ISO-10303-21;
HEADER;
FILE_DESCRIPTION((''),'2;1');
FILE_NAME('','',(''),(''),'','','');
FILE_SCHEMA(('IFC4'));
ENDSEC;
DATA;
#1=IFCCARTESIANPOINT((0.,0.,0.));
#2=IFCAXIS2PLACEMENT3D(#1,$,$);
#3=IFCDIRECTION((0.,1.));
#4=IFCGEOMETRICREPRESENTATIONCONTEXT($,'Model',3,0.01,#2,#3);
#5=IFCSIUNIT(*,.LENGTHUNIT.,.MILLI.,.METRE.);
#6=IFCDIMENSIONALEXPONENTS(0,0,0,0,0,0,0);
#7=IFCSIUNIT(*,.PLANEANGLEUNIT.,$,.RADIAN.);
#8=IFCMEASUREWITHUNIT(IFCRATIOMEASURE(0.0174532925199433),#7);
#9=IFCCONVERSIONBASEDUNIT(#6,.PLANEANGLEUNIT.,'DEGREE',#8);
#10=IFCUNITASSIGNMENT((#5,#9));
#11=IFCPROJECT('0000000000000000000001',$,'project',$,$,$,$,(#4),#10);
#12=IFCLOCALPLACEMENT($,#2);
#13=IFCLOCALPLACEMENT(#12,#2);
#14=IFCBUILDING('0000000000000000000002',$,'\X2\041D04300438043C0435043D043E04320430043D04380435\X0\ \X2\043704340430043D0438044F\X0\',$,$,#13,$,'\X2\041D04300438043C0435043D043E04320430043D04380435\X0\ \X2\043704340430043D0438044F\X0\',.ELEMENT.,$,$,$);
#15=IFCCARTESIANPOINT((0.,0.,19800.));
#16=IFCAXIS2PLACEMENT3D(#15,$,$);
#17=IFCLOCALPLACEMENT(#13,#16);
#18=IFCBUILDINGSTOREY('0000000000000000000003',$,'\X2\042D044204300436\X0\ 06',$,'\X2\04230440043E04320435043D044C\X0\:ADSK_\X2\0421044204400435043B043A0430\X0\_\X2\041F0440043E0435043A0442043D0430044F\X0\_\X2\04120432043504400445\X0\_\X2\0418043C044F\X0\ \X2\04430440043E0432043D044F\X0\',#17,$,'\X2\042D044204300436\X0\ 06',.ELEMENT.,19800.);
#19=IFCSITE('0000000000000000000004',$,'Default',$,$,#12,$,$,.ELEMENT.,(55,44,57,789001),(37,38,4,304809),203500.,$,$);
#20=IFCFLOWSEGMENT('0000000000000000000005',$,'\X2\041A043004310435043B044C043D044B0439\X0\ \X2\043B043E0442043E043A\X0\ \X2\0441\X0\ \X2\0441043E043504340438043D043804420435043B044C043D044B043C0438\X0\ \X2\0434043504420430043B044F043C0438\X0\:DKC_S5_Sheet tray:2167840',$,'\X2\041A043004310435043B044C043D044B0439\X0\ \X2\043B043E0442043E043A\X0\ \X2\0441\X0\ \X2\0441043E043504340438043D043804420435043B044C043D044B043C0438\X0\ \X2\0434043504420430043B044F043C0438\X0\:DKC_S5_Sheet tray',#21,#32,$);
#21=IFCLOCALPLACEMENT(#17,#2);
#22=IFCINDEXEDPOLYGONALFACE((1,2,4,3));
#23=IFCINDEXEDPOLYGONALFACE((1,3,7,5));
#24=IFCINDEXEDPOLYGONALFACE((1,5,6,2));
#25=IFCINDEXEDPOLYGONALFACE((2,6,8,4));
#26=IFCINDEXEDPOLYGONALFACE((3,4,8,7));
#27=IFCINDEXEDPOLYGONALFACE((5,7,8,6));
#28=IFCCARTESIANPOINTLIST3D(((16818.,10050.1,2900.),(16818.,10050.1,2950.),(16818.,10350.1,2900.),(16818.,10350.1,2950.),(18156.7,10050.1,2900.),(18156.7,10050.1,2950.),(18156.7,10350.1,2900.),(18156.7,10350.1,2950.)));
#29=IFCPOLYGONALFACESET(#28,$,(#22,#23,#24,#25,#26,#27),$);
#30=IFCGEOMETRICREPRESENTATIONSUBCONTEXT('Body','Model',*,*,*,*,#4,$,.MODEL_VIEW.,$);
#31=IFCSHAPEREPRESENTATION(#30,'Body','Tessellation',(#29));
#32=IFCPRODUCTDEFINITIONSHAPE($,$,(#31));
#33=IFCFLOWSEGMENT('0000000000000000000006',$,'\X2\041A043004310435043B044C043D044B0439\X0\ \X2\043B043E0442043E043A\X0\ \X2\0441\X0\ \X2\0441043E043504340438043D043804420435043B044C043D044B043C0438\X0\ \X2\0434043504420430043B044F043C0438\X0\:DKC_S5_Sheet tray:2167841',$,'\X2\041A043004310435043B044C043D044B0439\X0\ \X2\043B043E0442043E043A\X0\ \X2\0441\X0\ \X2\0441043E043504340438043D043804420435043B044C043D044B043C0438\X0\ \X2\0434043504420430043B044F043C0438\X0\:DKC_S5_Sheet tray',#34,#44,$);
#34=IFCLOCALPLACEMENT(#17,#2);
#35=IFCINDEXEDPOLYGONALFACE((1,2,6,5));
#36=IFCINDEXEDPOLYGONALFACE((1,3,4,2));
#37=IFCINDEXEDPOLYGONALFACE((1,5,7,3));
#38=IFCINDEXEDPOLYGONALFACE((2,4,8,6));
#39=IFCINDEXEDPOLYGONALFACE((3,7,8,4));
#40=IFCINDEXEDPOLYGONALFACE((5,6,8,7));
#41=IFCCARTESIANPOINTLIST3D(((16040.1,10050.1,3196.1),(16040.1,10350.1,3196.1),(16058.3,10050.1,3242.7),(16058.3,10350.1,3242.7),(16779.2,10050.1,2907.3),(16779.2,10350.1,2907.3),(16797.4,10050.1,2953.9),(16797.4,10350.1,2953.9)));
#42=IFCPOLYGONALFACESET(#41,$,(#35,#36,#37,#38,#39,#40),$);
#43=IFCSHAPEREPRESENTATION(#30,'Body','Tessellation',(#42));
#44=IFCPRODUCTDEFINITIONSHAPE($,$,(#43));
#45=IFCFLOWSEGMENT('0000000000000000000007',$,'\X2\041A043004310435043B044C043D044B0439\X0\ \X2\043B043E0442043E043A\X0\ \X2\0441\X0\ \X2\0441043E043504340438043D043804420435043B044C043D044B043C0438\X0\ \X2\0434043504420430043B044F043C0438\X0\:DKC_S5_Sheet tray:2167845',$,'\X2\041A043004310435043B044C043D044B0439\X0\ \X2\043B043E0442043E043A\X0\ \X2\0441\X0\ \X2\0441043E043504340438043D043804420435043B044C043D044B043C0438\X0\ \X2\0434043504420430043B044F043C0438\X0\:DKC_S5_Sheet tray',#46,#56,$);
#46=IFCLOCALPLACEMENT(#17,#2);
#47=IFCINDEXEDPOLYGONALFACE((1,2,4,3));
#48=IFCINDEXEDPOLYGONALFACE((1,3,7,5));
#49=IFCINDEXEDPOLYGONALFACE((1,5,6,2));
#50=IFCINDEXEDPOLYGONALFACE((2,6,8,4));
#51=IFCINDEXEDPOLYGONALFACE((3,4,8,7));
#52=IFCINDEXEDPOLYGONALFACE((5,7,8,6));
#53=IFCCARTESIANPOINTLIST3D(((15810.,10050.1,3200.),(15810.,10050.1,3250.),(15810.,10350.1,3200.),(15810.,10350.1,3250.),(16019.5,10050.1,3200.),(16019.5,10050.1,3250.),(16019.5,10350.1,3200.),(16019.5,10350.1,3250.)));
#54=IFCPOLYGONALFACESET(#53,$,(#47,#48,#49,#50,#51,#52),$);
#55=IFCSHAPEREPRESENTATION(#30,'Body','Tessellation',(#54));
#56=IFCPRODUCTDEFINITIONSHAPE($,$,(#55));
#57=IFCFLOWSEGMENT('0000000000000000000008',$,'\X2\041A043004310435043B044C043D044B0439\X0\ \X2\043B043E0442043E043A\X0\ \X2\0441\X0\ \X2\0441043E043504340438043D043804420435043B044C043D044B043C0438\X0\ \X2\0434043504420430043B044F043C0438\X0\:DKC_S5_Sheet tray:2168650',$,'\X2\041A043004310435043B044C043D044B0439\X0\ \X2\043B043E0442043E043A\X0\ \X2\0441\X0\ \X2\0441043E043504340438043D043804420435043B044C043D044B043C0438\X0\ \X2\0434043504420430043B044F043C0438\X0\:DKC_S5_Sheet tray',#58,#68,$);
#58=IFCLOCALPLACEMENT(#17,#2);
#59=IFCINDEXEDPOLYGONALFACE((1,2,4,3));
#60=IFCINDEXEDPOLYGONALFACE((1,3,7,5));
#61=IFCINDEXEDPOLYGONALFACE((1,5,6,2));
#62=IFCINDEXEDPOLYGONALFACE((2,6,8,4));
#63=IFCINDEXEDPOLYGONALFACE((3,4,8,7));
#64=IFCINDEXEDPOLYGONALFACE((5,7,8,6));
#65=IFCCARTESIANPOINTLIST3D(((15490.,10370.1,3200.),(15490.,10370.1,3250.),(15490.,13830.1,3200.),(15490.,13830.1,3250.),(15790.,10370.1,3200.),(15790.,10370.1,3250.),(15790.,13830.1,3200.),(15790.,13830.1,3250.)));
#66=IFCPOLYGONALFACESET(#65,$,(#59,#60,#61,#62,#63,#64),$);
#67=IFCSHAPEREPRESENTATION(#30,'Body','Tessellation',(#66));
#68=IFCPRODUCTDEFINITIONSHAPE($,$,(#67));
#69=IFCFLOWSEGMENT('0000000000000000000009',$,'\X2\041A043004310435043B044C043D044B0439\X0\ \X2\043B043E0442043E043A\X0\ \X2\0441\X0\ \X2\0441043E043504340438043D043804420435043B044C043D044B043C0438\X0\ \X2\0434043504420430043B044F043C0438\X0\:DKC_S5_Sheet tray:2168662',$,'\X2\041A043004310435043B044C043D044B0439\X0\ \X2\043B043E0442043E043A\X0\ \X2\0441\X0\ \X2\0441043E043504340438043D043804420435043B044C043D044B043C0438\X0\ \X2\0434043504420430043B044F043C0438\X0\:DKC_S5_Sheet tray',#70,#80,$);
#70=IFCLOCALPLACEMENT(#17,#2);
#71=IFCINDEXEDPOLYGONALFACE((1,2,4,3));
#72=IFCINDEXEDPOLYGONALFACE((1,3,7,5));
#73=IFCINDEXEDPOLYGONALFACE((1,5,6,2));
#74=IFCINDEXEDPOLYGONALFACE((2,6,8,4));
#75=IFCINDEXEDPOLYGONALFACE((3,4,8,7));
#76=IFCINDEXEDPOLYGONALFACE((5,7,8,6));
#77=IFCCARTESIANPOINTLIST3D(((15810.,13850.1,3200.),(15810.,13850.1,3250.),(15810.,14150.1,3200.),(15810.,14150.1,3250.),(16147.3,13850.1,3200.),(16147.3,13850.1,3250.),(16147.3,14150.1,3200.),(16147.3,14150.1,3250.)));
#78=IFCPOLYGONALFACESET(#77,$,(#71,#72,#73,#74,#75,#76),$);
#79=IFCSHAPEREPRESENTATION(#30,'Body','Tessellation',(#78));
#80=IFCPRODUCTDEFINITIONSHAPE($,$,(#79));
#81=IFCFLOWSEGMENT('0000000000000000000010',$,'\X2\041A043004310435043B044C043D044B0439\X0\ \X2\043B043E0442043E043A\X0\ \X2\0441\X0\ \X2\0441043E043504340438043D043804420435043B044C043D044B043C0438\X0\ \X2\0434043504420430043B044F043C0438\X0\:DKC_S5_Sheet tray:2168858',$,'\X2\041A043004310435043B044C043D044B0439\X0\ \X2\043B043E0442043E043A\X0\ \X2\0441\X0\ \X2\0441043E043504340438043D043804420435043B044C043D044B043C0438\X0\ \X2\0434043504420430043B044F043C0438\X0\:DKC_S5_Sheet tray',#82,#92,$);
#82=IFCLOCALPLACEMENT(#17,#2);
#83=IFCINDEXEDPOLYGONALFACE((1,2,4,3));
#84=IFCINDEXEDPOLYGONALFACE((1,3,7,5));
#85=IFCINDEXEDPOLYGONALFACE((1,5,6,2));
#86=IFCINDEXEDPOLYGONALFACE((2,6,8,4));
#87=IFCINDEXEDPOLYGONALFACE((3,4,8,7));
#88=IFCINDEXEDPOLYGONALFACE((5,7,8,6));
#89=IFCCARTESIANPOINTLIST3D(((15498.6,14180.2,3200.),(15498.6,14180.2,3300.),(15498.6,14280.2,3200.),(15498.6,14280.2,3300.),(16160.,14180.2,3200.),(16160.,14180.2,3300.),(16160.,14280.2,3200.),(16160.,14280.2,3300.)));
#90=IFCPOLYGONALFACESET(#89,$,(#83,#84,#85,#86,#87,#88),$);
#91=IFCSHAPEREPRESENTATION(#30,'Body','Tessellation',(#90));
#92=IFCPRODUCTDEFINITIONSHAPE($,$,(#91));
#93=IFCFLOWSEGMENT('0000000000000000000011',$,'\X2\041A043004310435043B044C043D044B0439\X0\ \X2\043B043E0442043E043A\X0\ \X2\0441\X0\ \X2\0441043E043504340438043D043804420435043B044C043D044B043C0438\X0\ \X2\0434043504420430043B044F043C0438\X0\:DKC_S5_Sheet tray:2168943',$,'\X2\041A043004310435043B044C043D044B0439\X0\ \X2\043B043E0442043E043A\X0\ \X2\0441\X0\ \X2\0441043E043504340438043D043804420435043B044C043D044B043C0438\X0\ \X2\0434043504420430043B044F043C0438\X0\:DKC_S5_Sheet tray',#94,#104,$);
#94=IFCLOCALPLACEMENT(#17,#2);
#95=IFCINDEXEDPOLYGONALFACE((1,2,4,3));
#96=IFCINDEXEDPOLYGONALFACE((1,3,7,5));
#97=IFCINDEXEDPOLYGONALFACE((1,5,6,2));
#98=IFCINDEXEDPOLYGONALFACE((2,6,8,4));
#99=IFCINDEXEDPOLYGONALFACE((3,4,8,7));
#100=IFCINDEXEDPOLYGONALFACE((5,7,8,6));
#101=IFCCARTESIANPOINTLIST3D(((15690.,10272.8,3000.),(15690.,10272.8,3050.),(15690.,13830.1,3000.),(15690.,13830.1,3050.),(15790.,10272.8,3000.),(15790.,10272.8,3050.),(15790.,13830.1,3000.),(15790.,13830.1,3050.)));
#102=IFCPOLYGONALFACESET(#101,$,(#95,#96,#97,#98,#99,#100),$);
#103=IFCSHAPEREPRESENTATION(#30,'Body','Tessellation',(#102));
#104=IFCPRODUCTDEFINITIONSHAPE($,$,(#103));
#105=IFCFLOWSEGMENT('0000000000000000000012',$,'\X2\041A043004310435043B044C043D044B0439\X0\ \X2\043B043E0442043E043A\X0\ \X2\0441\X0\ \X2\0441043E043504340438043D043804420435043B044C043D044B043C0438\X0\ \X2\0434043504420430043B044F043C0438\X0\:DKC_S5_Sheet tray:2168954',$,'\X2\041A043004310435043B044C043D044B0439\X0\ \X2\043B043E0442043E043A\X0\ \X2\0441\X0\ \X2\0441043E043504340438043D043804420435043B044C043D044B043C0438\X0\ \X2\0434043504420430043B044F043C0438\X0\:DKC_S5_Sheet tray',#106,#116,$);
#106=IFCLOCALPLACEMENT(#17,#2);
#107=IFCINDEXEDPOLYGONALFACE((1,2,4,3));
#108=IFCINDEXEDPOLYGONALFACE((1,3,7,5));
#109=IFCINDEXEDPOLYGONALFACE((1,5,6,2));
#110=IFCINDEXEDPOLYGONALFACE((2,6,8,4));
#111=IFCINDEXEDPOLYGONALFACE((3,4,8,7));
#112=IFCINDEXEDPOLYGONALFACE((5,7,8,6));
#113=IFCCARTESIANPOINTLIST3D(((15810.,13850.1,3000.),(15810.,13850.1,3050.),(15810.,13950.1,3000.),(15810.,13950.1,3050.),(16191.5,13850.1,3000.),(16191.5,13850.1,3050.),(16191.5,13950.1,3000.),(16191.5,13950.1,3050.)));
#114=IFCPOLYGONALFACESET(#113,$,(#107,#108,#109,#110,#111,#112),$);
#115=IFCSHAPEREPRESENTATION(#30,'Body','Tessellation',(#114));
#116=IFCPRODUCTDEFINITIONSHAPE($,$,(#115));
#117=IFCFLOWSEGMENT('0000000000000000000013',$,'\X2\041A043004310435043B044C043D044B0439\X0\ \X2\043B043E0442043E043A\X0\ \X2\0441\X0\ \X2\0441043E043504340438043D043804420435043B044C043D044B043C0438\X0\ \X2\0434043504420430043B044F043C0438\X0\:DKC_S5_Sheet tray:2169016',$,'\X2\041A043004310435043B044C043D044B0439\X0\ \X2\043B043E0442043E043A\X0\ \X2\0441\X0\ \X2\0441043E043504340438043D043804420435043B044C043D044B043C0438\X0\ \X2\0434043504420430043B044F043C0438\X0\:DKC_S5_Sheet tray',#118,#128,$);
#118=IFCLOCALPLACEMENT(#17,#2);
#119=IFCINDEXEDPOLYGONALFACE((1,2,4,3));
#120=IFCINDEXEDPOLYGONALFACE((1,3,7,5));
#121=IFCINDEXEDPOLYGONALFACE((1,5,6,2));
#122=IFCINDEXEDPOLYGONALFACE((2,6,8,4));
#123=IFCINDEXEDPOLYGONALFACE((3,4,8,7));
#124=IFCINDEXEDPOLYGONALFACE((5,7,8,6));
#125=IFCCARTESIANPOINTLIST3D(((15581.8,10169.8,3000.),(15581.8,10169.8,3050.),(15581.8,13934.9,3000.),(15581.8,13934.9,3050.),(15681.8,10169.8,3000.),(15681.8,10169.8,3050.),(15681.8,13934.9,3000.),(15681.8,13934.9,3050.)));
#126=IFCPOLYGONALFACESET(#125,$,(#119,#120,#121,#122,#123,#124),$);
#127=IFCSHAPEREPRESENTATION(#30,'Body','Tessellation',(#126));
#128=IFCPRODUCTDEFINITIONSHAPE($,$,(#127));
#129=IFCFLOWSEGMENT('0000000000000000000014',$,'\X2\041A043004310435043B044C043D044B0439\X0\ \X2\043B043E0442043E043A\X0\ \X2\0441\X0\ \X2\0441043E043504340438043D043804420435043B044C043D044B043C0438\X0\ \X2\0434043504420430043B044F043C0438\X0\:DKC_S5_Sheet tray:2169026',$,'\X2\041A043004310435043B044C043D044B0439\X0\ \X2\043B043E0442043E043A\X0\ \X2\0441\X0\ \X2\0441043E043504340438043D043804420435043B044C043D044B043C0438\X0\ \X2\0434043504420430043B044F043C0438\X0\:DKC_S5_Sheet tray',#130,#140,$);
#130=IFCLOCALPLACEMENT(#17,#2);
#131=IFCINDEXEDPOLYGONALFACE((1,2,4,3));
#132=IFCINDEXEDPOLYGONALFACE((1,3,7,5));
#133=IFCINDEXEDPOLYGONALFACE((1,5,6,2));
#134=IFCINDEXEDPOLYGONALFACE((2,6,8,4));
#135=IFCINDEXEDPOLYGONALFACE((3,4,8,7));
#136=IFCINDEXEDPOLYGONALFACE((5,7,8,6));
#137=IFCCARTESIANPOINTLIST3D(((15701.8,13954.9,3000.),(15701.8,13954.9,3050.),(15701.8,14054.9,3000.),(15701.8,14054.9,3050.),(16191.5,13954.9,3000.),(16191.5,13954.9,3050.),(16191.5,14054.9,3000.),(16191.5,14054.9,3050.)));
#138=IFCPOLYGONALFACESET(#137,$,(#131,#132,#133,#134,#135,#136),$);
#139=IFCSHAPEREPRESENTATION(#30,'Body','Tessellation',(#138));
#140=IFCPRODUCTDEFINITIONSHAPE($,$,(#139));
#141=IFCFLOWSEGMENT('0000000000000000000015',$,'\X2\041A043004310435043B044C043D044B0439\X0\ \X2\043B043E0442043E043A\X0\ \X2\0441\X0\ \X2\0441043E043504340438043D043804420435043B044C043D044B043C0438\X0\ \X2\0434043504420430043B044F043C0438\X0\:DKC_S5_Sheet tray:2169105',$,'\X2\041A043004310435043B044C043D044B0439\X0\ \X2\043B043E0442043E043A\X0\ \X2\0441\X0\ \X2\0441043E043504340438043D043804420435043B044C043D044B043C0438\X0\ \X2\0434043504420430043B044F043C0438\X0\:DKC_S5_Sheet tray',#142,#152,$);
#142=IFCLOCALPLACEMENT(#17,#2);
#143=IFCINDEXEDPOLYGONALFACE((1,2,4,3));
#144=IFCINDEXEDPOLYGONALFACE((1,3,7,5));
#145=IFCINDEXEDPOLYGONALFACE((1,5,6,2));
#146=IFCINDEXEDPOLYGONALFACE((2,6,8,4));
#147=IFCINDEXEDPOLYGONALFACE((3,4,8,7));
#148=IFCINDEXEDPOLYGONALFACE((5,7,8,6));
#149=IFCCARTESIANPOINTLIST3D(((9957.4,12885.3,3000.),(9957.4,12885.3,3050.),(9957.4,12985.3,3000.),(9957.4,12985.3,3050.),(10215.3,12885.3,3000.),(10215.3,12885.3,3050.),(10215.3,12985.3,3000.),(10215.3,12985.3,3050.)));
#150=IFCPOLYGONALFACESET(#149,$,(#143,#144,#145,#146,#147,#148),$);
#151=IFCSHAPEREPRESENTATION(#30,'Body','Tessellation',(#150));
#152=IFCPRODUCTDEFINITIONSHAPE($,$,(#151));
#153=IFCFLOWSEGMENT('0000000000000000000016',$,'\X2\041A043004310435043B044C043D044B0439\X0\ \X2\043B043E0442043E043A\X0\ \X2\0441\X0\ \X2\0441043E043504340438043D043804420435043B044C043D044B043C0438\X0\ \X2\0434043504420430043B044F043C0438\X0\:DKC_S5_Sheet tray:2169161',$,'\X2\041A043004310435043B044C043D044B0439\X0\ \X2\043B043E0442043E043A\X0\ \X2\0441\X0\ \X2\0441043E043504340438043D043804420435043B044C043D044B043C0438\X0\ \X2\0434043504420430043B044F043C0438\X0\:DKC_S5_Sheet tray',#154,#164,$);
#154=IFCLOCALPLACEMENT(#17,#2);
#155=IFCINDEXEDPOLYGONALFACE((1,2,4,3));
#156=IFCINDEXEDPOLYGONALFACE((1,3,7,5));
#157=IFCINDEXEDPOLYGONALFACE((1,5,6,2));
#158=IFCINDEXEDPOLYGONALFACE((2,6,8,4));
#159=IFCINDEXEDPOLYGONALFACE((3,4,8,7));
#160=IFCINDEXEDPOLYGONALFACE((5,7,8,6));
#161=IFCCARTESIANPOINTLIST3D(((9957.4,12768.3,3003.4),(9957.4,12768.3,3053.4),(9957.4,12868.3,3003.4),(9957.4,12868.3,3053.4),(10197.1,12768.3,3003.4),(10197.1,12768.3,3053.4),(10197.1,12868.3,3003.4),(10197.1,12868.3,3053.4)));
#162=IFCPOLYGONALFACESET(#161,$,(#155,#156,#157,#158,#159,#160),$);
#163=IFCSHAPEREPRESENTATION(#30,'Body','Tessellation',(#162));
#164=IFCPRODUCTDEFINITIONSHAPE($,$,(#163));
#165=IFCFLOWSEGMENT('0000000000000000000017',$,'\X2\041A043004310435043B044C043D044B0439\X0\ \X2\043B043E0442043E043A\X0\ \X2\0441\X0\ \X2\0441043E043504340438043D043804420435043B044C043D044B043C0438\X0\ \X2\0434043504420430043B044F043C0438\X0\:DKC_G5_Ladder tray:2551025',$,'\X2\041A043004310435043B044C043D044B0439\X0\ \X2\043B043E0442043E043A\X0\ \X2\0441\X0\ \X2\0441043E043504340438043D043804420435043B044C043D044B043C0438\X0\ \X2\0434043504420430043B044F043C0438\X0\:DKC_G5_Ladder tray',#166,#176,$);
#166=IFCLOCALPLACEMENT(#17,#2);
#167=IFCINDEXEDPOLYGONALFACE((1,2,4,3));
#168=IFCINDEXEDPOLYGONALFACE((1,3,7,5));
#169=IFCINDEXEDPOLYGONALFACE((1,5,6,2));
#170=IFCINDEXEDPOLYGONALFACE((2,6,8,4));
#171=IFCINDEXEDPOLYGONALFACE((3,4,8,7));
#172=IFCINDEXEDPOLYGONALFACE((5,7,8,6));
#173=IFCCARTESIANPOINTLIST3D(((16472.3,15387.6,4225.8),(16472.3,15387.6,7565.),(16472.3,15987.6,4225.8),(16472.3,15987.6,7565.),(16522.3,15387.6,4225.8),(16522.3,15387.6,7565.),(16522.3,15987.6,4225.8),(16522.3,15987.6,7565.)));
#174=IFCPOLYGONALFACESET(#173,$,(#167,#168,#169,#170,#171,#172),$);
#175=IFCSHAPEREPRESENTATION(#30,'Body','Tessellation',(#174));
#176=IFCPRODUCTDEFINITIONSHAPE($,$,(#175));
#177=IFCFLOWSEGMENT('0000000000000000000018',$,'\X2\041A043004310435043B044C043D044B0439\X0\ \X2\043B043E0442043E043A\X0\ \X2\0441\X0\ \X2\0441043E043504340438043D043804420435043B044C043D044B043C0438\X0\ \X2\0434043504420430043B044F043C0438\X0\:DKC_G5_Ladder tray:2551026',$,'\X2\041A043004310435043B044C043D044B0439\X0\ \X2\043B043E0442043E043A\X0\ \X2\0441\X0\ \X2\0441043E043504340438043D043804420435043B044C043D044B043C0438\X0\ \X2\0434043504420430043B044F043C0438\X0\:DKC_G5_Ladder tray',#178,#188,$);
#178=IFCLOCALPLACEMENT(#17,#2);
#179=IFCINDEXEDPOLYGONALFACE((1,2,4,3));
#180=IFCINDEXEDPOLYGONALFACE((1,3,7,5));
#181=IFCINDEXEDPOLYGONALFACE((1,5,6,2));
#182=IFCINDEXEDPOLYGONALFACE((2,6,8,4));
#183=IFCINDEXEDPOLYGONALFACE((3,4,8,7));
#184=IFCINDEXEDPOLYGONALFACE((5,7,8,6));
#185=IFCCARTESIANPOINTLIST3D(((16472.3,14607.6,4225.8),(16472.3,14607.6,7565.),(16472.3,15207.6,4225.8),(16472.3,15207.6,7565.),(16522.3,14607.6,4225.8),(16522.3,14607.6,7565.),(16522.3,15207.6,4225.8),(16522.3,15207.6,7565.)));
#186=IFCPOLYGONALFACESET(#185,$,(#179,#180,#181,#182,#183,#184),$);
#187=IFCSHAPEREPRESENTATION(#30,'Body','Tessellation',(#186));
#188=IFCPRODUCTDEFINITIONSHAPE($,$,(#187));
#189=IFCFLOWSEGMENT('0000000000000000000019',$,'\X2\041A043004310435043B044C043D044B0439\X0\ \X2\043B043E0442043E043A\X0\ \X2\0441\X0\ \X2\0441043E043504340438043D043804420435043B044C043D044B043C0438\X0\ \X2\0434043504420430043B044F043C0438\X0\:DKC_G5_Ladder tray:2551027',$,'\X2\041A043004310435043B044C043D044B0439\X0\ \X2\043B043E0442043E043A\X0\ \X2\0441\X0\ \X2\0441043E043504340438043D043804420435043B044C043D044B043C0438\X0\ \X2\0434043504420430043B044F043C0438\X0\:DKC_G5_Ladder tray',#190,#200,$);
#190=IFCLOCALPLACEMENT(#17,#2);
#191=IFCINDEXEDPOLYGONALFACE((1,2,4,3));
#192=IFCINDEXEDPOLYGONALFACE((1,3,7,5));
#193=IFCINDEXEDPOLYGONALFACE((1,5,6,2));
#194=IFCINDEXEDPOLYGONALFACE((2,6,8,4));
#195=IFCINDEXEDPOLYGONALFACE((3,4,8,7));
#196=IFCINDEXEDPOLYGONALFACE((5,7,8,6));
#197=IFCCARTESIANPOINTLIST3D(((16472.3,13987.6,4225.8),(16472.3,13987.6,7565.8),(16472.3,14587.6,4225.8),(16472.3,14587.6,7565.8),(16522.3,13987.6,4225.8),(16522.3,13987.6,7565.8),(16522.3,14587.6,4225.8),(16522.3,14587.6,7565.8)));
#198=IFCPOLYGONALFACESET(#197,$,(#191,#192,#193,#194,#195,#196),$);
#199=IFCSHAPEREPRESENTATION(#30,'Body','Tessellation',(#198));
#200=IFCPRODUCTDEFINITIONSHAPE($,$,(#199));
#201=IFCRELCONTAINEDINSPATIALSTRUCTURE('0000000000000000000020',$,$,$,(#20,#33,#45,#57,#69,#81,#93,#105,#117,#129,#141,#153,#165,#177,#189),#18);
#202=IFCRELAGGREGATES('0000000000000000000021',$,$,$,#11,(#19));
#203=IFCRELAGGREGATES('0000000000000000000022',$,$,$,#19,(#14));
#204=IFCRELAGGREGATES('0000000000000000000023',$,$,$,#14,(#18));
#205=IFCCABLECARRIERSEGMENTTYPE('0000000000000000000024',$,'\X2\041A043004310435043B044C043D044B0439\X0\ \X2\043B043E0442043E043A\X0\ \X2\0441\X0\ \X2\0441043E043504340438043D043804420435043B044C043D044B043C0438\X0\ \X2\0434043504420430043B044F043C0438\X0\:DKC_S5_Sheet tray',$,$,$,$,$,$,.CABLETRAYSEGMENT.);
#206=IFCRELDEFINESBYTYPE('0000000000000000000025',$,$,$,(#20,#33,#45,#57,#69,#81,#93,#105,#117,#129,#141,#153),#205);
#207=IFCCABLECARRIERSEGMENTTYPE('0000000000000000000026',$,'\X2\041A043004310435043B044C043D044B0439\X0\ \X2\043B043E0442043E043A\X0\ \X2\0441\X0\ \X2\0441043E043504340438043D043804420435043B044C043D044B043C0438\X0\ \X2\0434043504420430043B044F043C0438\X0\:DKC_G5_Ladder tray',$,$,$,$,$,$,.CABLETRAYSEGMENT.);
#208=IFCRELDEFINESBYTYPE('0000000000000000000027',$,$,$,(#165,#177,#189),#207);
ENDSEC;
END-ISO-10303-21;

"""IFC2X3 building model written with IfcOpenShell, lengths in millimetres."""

from ifc_helpers import new_model, entity, si_unit, converted_unit, direction, frame, frame_2d, origin, origin_2d_with_axis, place, context, subcontext, project, spatial, rectangle, extrude, type_object, element, save


model = new_model("IFC2X3")

# Units and contexts
model_context = context("Model", 3, precision=0.01, world=origin(), true_north=direction((0.0, 1.0)))
body_context = subcontext(model_context, "Body", "Model", "MODEL_VIEW")
ifc_project = project(units=[si_unit("LENGTHUNIT", "METRE", prefix="MILLI"), converted_unit("PLANEANGLEUNIT", "DEGREE", entity("IfcRatioMeasure", 0.0174532925199433), si_unit("PLANEANGLEUNIT", "RADIAN"), dimensions=[0, 0, 0, 0, 0, 0, 0])], contexts=[model_context])

# Site, building, storey
site_placement = place(None, frame((0.0, 0.0, 0.0)))
site = spatial("IfcSite", under=ifc_project, at=site_placement, Name="Default", CompositionType="ELEMENT", RefLatitude=(55, 44, 57, 789001), RefLongitude=(37, 38, 4, 304809), RefElevation=203500.0)
building_placement = place(site_placement, origin())
building = spatial("IfcBuilding", under=site, at=building_placement, Name="Наименование здания", LongName="Наименование здания", CompositionType="ELEMENT")
storey_placement = place(building_placement, frame((0.0, 0.0, 19800.0)))
storey = spatial("IfcBuildingStorey", under=building, at=storey_placement, Name="Этаж 06", ObjectType="Уровень:ADSK_Стрелка_Проектная_Вверх_Имя уровня", LongName="Этаж 06", CompositionType="ELEMENT", Elevation=19800.0)

# Flow segments
cable_carrier_segment_type_1 = type_object("IfcCableCarrierSegmentType", Name="Кабельный лоток с соединительными деталями:DKC_S5_Sheet tray", PredefinedType="CABLETRAYSEGMENT")
flow_segment_1_placement = place(storey_placement, frame((16818.0, 10050.1, 2900.0)))
element("IfcFlowSegment", 1, at=flow_segment_1_placement, inside=storey, type_object=cable_carrier_segment_type_1, Name="Кабельный лоток с соединительными деталями:DKC_S5_Sheet tray:2167840", ObjectType="Кабельный лоток с соединительными деталями:DKC_S5_Sheet tray", context=body_context, shape_type="SweptSolid", body=[
    extrude(rectangle(XDim=1338.8, YDim=300.0, at=frame_2d((0.0, 0.0), x_axis=(1.0, 0.0))), frame((669.4, 150.0, 0.0)), (0.0, 0.0, 1.0), 50.0),
])
flow_segment_2_placement = place(storey_placement, frame((16040.1, 10050.1, 2907.3)))
element("IfcFlowSegment", 2, at=flow_segment_2_placement, inside=storey, type_object=cable_carrier_segment_type_1, Name="Кабельный лоток с соединительными деталями:DKC_S5_Sheet tray:2167841", ObjectType="Кабельный лоток с соединительными деталями:DKC_S5_Sheet tray", context=body_context, shape_type="SweptSolid", body=[
    extrude(rectangle(XDim=50.0, YDim=300.0, at=frame_2d((0.0, 0.0), x_axis=(0.0, 1.0))), frame((9.1, 150.0, 312.1), z_axis=(0.931413, 0.0, -0.363965), x_axis=(0.0, 1.0, 0.0)), (0.0, 0.0, 1.0), 793.5),
])
flow_segment_3_placement = place(storey_placement, frame((15810.0, 10050.1, 3200.0)))
element("IfcFlowSegment", 3, at=flow_segment_3_placement, inside=storey, type_object=cable_carrier_segment_type_1, Name="Кабельный лоток с соединительными деталями:DKC_S5_Sheet tray:2167845", ObjectType="Кабельный лоток с соединительными деталями:DKC_S5_Sheet tray", context=body_context, shape_type="SweptSolid", body=[
    extrude(rectangle(XDim=209.5, YDim=300.0, at=frame_2d((0.0, 0.0), x_axis=(1.0, 0.0))), frame((104.8, 150.0, 0.0), z_axis=(0.0, 0.0, 1.0), x_axis=(-1.0, 0.0, 0.0)), (0.0, 0.0, 1.0), 50.0),
])
flow_segment_4_placement = place(storey_placement, frame((15490.0, 10370.1, 3200.0)))
element("IfcFlowSegment", 4, at=flow_segment_4_placement, inside=storey, type_object=cable_carrier_segment_type_1, Name="Кабельный лоток с соединительными деталями:DKC_S5_Sheet tray:2168650", ObjectType="Кабельный лоток с соединительными деталями:DKC_S5_Sheet tray", context=body_context, shape_type="SweptSolid", body=[
    extrude(rectangle(XDim=3460.0, YDim=300.0, at=frame_2d((0.0, 0.0), x_axis=(1.0, 0.0))), frame((150.0, 1730.0, 0.0), z_axis=(0.0, 0.0, 1.0), x_axis=(0.0, 1.0, 0.0)), (0.0, 0.0, 1.0), 50.0),
])
flow_segment_5_placement = place(storey_placement, frame((15810.0, 13850.1, 3200.0)))
element("IfcFlowSegment", 5, at=flow_segment_5_placement, inside=storey, type_object=cable_carrier_segment_type_1, Name="Кабельный лоток с соединительными деталями:DKC_S5_Sheet tray:2168662", ObjectType="Кабельный лоток с соединительными деталями:DKC_S5_Sheet tray", context=body_context, shape_type="SweptSolid", body=[
    extrude(rectangle(XDim=337.3, YDim=300.0, at=origin_2d_with_axis()), frame((168.7, 150.0, 0.0)), (0.0, 0.0, 1.0), 50.0),
])
flow_segment_6_placement = place(storey_placement, frame((15498.6, 14180.2, 3200.0)))
element("IfcFlowSegment", 6, at=flow_segment_6_placement, inside=storey, type_object=cable_carrier_segment_type_1, Name="Кабельный лоток с соединительными деталями:DKC_S5_Sheet tray:2168858", ObjectType="Кабельный лоток с соединительными деталями:DKC_S5_Sheet tray", context=body_context, shape_type="SweptSolid", body=[
    extrude(rectangle(XDim=661.4, YDim=100.0, at=frame_2d((0.0, 0.0), x_axis=(1.0, 0.0))), frame((330.7, 50.0, 0.0)), (0.0, 0.0, 1.0), 100.0),
])
flow_segment_7_placement = place(storey_placement, frame((15690.0, 10272.8, 3000.0)))
element("IfcFlowSegment", 7, at=flow_segment_7_placement, inside=storey, type_object=cable_carrier_segment_type_1, Name="Кабельный лоток с соединительными деталями:DKC_S5_Sheet tray:2168943", ObjectType="Кабельный лоток с соединительными деталями:DKC_S5_Sheet tray", context=body_context, shape_type="SweptSolid", body=[
    extrude(rectangle(XDim=3557.3, YDim=100.0, at=frame_2d((0.0, 0.0), x_axis=(1.0, 0.0))), frame((50.0, 1778.6, 0.0), z_axis=(0.0, 0.0, 1.0), x_axis=(0.0, 1.0, 0.0)), (0.0, 0.0, 1.0), 50.0),
])
flow_segment_8_placement = place(storey_placement, frame((15810.0, 13850.1, 3000.0)))
element("IfcFlowSegment", 8, at=flow_segment_8_placement, inside=storey, type_object=cable_carrier_segment_type_1, Name="Кабельный лоток с соединительными деталями:DKC_S5_Sheet tray:2168954", ObjectType="Кабельный лоток с соединительными деталями:DKC_S5_Sheet tray", context=body_context, shape_type="SweptSolid", body=[
    extrude(rectangle(XDim=381.5, YDim=100.0, at=frame_2d((0.0, 0.0), x_axis=(1.0, 0.0))), frame((190.8, 50.0, 0.0)), (0.0, 0.0, 1.0), 50.0),
])
flow_segment_9_placement = place(storey_placement, frame((15581.8, 10169.8, 3000.0)))
element("IfcFlowSegment", 9, at=flow_segment_9_placement, inside=storey, type_object=cable_carrier_segment_type_1, Name="Кабельный лоток с соединительными деталями:DKC_S5_Sheet tray:2169016", ObjectType="Кабельный лоток с соединительными деталями:DKC_S5_Sheet tray", context=body_context, shape_type="SweptSolid", body=[
    extrude(rectangle(XDim=3765.1, YDim=100.0, at=origin_2d_with_axis()), frame((50.0, 1882.6, 0.0), z_axis=(0.0, 0.0, 1.0), x_axis=(0.0, 1.0, 0.0)), (0.0, 0.0, 1.0), 50.0),
])
flow_segment_10_placement = place(storey_placement, frame((15701.8, 13954.9, 3000.0)))
element("IfcFlowSegment", 10, at=flow_segment_10_placement, inside=storey, type_object=cable_carrier_segment_type_1, Name="Кабельный лоток с соединительными деталями:DKC_S5_Sheet tray:2169026", ObjectType="Кабельный лоток с соединительными деталями:DKC_S5_Sheet tray", context=body_context, shape_type="SweptSolid", body=[
    extrude(rectangle(XDim=489.7, YDim=100.0, at=frame_2d((0.0, 0.0), x_axis=(1.0, 0.0))), frame((244.9, 50.0, 0.0)), (0.0, 0.0, 1.0), 50.0),
])
flow_segment_11_placement = place(storey_placement, frame((9957.4, 12885.3, 3000.0)))
element("IfcFlowSegment", 11, at=flow_segment_11_placement, inside=storey, type_object=cable_carrier_segment_type_1, Name="Кабельный лоток с соединительными деталями:DKC_S5_Sheet tray:2169105", ObjectType="Кабельный лоток с соединительными деталями:DKC_S5_Sheet tray", context=body_context, shape_type="SweptSolid", body=[
    extrude(rectangle(XDim=257.9, YDim=100.0, at=origin_2d_with_axis()), frame((129.0, 50.0, 0.0), z_axis=(0.0, 0.0, 1.0), x_axis=(-1.0, 0.0, 0.0)), (0.0, 0.0, 1.0), 50.0),
])
flow_segment_12_placement = place(storey_placement, frame((9957.4, 12768.3, 3003.4)))
element("IfcFlowSegment", 12, at=flow_segment_12_placement, inside=storey, type_object=cable_carrier_segment_type_1, Name="Кабельный лоток с соединительными деталями:DKC_S5_Sheet tray:2169161", ObjectType="Кабельный лоток с соединительными деталями:DKC_S5_Sheet tray", context=body_context, shape_type="SweptSolid", body=[
    extrude(rectangle(XDim=239.8, YDim=100.0, at=frame_2d((0.0, 0.0), x_axis=(1.0, 0.0))), frame((119.9, 50.0, 0.0), z_axis=(0.0, 0.0, 1.0), x_axis=(-1.0, 0.0, 0.0)), (0.0, 0.0, 1.0), 50.0),
])

# Flow segments
cable_carrier_segment_type_2 = type_object("IfcCableCarrierSegmentType", Name="Кабельный лоток с соединительными деталями:DKC_G5_Ladder tray", PredefinedType="CABLETRAYSEGMENT")
for number, where, name in (
    (13, (16472.3, 15387.6, 4225.8), "Кабельный лоток с соединительными деталями:DKC_G5_Ladder tray:2551025"),
    (14, (16472.3, 14607.6, 4225.8), "Кабельный лоток с соединительными деталями:DKC_G5_Ladder tray:2551026"),
):
    element("IfcFlowSegment", number, at=place(storey_placement, frame(where)), inside=storey, type_object=cable_carrier_segment_type_2, Name=name, ObjectType="Кабельный лоток с соединительными деталями:DKC_G5_Ladder tray", context=body_context, shape_type="SweptSolid", body=[
        extrude(rectangle(XDim=50.0, YDim=600.0, at=origin_2d_with_axis()), frame((25.0, 300.0, 0.0), z_axis=(0.0, 0.0, 1.0), x_axis=(-1.0, 0.0, 0.0)), (0.0, 0.0, 1.0), 3339.2),
    ])
flow_segment_13_placement = place(storey_placement, frame((16472.3, 13987.6, 4225.8)))
element("IfcFlowSegment", 15, at=flow_segment_13_placement, inside=storey, type_object=cable_carrier_segment_type_2, Name="Кабельный лоток с соединительными деталями:DKC_G5_Ladder tray:2551027", ObjectType="Кабельный лоток с соединительными деталями:DKC_G5_Ladder tray", context=body_context, shape_type="SweptSolid", body=[
    extrude(rectangle(XDim=50.0, YDim=600.0, at=origin_2d_with_axis()), frame((25.0, 300.0, 0.0), z_axis=(0.0, 0.0, 1.0), x_axis=(-1.0, 0.0, 0.0)), (0.0, 0.0, 1.0), 3340.0),
])

save(model, "model.ifc")
